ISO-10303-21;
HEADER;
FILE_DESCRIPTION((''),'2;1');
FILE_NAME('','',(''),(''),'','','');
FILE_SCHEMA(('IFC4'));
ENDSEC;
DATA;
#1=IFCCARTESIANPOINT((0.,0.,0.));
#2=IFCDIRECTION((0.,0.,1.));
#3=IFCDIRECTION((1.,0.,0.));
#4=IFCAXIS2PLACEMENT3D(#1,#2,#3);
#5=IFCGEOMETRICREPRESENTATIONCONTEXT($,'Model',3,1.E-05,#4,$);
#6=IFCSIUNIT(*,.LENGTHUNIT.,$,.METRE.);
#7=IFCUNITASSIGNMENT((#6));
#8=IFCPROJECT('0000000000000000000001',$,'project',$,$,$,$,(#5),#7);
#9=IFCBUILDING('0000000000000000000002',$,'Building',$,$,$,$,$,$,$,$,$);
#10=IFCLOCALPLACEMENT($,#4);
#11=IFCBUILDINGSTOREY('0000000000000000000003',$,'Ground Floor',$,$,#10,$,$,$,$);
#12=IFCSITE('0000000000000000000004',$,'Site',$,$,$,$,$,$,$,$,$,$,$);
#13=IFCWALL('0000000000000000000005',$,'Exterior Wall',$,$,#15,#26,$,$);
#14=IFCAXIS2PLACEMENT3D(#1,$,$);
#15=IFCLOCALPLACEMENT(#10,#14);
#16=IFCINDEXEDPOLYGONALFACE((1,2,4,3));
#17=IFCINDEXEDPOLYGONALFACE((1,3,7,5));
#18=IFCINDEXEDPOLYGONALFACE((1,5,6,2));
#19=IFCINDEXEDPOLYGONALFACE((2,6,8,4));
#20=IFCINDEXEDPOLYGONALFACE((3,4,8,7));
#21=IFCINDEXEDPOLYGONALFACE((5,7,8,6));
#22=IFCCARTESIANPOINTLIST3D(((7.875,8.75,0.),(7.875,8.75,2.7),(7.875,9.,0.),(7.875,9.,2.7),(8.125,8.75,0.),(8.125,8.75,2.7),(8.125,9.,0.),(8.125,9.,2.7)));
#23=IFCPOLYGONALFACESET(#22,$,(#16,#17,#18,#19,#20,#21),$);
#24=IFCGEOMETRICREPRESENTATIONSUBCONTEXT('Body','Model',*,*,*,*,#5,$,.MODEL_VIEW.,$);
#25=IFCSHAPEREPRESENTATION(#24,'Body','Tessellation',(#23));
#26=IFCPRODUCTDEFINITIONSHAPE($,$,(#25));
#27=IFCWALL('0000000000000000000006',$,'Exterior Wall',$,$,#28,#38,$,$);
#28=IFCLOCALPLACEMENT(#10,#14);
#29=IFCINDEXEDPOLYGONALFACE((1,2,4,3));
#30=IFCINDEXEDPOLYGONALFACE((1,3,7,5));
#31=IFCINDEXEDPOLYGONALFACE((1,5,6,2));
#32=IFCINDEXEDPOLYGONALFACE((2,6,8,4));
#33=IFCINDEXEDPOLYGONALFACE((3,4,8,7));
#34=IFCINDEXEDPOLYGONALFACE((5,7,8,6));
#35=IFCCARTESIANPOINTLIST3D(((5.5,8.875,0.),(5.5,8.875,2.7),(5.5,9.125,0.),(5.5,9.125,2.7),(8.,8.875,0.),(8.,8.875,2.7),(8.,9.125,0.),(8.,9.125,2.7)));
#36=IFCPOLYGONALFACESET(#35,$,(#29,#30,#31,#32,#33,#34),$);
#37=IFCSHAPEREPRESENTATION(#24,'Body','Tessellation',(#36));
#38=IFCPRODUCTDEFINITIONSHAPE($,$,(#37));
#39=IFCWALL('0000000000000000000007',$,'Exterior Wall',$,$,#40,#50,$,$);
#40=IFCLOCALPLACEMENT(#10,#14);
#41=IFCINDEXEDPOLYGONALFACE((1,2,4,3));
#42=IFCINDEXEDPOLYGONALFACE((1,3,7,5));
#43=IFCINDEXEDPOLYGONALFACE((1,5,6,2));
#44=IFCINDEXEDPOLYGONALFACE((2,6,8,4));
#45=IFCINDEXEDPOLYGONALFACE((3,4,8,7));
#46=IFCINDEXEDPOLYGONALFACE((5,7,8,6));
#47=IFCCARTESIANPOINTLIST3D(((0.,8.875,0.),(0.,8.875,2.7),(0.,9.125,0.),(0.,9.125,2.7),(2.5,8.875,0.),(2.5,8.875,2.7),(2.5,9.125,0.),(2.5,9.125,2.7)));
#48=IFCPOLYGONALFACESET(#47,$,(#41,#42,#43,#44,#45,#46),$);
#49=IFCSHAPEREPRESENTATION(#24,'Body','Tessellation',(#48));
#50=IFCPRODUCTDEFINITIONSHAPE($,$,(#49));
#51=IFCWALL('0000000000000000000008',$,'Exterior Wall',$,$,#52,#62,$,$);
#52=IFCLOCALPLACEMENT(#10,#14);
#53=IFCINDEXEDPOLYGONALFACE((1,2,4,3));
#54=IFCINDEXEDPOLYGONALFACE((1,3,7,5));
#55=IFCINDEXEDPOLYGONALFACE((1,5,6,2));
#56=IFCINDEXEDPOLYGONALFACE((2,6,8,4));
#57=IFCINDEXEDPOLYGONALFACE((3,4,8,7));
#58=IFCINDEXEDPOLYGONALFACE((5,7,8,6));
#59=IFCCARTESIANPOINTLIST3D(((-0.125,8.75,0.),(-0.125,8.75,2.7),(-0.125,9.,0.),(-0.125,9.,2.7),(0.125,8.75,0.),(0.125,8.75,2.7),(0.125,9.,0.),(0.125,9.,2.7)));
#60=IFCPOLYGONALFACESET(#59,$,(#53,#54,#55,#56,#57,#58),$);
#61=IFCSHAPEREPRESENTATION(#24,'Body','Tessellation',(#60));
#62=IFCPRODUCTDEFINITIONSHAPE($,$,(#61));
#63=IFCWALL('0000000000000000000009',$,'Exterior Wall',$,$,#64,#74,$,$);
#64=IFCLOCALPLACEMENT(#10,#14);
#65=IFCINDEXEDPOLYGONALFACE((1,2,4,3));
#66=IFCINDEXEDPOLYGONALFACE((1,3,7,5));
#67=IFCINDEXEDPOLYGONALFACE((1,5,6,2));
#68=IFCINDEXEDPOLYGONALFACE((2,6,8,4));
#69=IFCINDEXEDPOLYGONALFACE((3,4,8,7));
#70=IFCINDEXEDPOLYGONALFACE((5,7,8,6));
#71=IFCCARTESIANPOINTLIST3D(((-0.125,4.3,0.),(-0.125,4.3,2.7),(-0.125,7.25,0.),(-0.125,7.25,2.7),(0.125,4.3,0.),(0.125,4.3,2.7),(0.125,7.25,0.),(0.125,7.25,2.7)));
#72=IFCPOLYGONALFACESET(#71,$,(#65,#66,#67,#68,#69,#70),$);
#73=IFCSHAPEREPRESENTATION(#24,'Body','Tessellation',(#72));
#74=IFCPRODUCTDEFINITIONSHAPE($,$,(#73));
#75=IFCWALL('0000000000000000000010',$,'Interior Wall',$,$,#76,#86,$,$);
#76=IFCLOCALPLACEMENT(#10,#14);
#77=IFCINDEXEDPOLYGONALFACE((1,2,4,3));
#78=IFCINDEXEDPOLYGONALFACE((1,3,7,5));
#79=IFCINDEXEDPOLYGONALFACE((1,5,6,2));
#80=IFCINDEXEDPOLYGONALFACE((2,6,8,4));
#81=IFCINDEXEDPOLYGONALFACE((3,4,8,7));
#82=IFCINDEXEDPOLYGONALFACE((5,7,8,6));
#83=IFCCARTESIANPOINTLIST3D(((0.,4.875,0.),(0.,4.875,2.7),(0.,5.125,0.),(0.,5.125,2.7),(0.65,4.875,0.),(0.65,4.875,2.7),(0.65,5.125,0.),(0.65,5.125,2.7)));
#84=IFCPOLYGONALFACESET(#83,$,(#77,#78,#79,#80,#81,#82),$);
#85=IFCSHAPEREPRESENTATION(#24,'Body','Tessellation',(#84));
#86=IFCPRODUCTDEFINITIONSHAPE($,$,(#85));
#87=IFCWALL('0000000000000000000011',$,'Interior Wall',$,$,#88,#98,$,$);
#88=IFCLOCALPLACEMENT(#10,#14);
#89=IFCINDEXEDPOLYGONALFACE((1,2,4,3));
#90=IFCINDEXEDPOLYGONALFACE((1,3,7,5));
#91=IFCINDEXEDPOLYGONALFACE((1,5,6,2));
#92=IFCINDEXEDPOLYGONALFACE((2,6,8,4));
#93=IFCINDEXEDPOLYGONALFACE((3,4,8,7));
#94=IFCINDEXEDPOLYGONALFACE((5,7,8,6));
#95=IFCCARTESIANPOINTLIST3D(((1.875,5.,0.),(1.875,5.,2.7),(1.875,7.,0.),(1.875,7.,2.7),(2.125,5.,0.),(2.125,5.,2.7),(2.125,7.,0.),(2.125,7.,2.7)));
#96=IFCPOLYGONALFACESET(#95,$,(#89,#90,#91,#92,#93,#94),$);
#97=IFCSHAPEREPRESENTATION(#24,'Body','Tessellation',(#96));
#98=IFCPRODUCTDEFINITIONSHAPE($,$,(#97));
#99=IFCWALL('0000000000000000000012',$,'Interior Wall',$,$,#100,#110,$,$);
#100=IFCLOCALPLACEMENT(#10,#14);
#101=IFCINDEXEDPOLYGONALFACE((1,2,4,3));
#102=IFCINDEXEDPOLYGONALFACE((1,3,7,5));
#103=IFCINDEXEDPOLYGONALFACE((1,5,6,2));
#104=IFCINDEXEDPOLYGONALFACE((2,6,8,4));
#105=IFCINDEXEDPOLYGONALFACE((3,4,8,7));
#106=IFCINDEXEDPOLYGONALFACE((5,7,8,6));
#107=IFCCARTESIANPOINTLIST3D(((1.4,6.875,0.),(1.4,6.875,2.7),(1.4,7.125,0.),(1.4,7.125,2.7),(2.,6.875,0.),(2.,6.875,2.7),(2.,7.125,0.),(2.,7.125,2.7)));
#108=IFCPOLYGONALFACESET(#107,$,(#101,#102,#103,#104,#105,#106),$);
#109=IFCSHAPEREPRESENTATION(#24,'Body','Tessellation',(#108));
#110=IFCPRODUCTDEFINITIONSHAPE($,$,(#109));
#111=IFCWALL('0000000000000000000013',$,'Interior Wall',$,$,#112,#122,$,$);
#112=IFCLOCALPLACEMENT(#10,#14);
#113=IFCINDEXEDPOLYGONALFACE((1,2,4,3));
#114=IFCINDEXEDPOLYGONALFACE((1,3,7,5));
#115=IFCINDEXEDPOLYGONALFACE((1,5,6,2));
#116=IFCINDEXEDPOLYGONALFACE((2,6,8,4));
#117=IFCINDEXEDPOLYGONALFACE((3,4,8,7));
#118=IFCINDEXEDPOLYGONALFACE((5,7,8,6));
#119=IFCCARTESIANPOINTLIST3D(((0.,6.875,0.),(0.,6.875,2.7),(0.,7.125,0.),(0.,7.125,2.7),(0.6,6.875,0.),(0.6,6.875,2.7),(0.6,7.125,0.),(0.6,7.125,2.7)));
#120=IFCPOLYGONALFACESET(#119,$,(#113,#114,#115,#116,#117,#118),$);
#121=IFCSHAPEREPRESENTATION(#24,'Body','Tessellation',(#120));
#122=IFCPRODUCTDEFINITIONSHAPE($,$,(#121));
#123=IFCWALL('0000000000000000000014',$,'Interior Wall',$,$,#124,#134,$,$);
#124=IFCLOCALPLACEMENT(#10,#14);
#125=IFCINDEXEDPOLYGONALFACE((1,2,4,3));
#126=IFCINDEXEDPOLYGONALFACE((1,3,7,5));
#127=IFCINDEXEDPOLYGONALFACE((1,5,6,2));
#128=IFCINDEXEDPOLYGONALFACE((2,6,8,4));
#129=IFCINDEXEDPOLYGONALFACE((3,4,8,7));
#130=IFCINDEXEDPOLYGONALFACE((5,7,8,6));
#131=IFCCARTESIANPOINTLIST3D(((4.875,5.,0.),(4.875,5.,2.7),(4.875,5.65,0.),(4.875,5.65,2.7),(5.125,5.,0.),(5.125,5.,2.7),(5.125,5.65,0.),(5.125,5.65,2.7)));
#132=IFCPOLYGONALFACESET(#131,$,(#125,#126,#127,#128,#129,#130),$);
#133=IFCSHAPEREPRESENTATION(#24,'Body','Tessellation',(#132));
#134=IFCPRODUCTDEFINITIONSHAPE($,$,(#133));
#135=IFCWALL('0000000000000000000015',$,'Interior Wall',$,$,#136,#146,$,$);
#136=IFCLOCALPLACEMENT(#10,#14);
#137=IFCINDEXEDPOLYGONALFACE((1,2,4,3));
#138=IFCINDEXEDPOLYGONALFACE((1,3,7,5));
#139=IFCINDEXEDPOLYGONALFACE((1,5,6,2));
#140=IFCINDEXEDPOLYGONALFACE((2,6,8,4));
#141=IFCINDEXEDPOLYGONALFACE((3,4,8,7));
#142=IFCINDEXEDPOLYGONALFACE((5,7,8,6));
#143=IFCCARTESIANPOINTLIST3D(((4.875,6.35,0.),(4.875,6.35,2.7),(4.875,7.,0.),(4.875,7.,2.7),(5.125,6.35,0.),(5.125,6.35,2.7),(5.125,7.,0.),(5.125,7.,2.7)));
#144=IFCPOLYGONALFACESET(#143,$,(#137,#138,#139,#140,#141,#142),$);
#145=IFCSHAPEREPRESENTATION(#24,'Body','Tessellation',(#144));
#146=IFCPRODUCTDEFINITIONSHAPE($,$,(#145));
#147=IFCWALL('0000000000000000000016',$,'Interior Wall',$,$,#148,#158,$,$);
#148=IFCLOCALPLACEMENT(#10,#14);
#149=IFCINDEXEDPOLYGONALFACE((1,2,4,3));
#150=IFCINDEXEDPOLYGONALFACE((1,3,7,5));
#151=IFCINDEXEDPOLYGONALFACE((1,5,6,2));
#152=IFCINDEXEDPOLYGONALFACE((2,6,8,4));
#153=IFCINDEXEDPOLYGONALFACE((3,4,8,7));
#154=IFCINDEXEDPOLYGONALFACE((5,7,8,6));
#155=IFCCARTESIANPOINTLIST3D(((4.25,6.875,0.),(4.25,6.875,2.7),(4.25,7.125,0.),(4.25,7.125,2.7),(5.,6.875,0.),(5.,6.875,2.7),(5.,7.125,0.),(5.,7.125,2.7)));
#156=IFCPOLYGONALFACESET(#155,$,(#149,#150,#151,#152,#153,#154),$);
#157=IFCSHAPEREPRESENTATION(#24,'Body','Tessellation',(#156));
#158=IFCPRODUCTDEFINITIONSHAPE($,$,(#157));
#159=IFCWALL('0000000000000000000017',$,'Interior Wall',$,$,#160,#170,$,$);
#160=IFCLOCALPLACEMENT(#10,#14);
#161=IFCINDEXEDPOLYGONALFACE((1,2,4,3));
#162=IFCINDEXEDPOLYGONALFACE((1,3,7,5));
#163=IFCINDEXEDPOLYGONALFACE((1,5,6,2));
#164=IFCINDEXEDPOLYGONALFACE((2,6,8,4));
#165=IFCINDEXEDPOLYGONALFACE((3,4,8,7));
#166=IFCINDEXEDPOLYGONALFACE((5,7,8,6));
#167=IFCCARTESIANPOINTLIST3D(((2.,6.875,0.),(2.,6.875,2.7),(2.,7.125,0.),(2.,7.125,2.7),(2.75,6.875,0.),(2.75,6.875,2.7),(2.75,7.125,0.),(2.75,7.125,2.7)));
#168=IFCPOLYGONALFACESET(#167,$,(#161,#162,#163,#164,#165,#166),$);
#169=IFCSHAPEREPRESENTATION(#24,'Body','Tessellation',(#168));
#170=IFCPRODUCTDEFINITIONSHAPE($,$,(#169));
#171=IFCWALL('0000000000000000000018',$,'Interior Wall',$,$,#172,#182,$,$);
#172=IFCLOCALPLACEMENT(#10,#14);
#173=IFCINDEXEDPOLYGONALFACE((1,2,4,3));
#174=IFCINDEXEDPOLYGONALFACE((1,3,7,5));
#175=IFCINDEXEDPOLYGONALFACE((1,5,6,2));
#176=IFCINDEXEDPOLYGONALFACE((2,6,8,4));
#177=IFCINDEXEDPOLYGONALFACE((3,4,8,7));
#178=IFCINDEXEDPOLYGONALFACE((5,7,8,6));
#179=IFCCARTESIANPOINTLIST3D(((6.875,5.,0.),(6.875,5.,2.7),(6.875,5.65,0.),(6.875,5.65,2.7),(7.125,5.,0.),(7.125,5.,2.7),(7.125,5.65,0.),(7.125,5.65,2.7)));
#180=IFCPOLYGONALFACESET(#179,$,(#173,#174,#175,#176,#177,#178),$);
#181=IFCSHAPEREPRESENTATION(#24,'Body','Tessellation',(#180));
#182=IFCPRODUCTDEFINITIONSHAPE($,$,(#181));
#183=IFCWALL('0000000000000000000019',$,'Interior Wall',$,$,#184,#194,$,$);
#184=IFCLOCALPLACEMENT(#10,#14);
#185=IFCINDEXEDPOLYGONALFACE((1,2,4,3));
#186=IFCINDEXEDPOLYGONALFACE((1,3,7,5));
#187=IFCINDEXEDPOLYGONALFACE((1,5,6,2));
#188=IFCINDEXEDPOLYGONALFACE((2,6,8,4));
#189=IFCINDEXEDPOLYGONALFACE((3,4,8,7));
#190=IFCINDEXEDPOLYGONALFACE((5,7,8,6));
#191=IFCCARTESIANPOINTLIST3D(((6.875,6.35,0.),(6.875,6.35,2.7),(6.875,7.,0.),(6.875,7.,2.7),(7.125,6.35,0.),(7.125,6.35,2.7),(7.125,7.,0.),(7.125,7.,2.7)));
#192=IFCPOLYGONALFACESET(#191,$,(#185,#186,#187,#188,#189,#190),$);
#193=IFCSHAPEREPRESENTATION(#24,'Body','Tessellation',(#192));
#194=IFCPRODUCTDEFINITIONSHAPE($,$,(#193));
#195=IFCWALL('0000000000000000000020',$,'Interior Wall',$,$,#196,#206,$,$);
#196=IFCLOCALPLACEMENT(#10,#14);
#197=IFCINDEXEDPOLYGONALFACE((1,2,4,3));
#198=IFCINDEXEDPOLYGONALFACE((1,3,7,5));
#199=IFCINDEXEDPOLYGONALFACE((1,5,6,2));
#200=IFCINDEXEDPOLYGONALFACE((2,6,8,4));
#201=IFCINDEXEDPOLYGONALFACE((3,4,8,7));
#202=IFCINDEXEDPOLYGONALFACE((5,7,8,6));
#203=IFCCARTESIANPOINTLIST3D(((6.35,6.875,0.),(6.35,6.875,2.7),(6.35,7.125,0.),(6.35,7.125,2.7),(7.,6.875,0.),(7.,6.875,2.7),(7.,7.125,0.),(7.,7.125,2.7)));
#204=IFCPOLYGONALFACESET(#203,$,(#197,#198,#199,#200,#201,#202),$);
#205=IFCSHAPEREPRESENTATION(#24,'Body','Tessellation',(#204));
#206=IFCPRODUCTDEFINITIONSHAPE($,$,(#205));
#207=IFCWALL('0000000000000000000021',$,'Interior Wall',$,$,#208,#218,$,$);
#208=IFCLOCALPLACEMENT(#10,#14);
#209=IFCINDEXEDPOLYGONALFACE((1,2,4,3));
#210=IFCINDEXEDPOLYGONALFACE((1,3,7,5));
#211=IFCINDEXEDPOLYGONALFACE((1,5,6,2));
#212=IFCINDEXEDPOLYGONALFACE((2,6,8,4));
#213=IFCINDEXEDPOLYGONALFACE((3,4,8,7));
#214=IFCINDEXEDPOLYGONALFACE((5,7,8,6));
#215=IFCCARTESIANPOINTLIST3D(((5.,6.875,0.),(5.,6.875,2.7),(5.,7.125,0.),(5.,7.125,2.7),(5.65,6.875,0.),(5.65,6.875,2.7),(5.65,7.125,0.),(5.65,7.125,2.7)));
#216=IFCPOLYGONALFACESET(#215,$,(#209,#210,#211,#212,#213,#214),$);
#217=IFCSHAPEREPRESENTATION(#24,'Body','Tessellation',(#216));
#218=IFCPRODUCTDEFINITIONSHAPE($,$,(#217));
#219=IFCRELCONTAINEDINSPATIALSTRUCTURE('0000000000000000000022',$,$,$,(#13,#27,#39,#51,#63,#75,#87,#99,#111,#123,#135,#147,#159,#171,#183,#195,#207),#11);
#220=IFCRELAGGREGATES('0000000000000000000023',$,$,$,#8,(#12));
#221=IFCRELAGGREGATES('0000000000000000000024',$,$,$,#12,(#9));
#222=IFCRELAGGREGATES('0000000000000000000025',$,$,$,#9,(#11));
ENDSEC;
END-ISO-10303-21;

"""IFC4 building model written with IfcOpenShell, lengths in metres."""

from ifc_helpers import new_model, si_unit, frame, origin_with_axes, place, context, subcontext, project, spatial, indexed_curve, outline, extrude, element, save


model = new_model("IFC4")

# Units and contexts
model_context = context("Model", 3, precision=1e-05, world=origin_with_axes())
body_context = subcontext(model_context, "Body", "Model", "MODEL_VIEW")
ifc_project = project(units=[si_unit("LENGTHUNIT", "METRE")], contexts=[model_context])

# Site, building, storey
site = spatial("IfcSite", under=ifc_project, Name="Site")
building = spatial("IfcBuilding", under=site, Name="Building")
storey_placement = place(None, origin_with_axes())
storey = spatial("IfcBuildingStorey", under=building, at=storey_placement, Name="Ground Floor")

# Walls
wall_1_placement = place(storey_placement, frame((8.0, 8.75, 0.0), z_axis=(0.0, 0.0, 1.0), x_axis=(0.0, 1.0, 0.0)))
element("IfcWall", 1, at=wall_1_placement, inside=storey, Name="Exterior Wall", context=body_context, shape_type="SweptSolid", body=[
    extrude(outline(indexed_curve([(0.0, 0.0), (0.0, 0.25), (0.25, 0.25), (0.25, 0.0), (0.0, 0.0)], self_intersect=False)), frame((0.0, -0.125, 0.0), z_axis=(0.0, 0.0, 1.0), x_axis=(1.0, 0.0, 0.0)), (0.0, 0.0, 1.0), 2.7),
])
for number, where, z_axis, x_axis, name in (
    (2, (8.0, 9.0, 0.0), (0.0, 0.0, 1.0), (-1.0, 0.0, 0.0), "Exterior Wall"),
    (3, (2.5, 9.0, 0.0), (0.0, 0.0, 1.0), (-1.0, 0.0, 0.0), "Exterior Wall"),
):
    element("IfcWall", number, at=place(storey_placement, frame(where, z_axis=z_axis, x_axis=x_axis)), inside=storey, Name=name, context=body_context, shape_type="SweptSolid", body=[
        extrude(outline(indexed_curve([(0.0, 0.0), (0.0, 0.25), (2.5, 0.25), (2.5, 0.0), (0.0, 0.0)], self_intersect=False)), frame((0.0, -0.125, 0.0), z_axis=(0.0, 0.0, 1.0), x_axis=(1.0, 0.0, 0.0)), (0.0, 0.0, 1.0), 2.7),
    ])
wall_2_placement = place(storey_placement, frame((0.0, 9.0, 0.0), z_axis=(0.0, 0.0, 1.0), x_axis=(0.0, -1.0, 0.0)))
element("IfcWall", 4, at=wall_2_placement, inside=storey, Name="Exterior Wall", context=body_context, shape_type="SweptSolid", body=[
    extrude(outline(indexed_curve([(0.0, 0.0), (0.0, 0.25), (0.25, 0.25), (0.25, 0.0), (0.0, 0.0)], self_intersect=False)), frame((0.0, -0.125, 0.0), z_axis=(0.0, 0.0, 1.0), x_axis=(1.0, 0.0, 0.0)), (0.0, 0.0, 1.0), 2.7),
])
wall_3_placement = place(storey_placement, frame((0.0, 7.25, 0.0), z_axis=(0.0, 0.0, 1.0), x_axis=(0.0, -1.0, 0.0)))
element("IfcWall", 5, at=wall_3_placement, inside=storey, Name="Exterior Wall", context=body_context, shape_type="SweptSolid", body=[
    extrude(outline(indexed_curve([(0.0, 0.0), (0.0, 0.25), (2.95, 0.25), (2.95, 0.0), (0.0, 0.0)], self_intersect=False)), frame((0.0, -0.125, 0.0), z_axis=(0.0, 0.0, 1.0), x_axis=(1.0, 0.0, 0.0)), (0.0, 0.0, 1.0), 2.7),
])
wall_4_placement = place(storey_placement, frame((0.65, 5.0, 0.0), z_axis=(0.0, 0.0, 1.0), x_axis=(-1.0, 0.0, 0.0)))
element("IfcWall", 6, at=wall_4_placement, inside=storey, Name="Interior Wall", context=body_context, shape_type="SweptSolid", body=[
    extrude(outline(indexed_curve([(0.0, 0.0), (0.0, 0.25), (0.65, 0.25), (0.65, 0.0), (0.0, 0.0)], self_intersect=False)), frame((0.0, -0.125, 0.0), z_axis=(0.0, 0.0, 1.0), x_axis=(1.0, 0.0, 0.0)), (0.0, 0.0, 1.0), 2.7),
])
wall_5_placement = place(storey_placement, frame((2.0, 5.0, 0.0), z_axis=(0.0, 0.0, 1.0), x_axis=(0.0, 1.0, 0.0)))
element("IfcWall", 7, at=wall_5_placement, inside=storey, Name="Interior Wall", context=body_context, shape_type="SweptSolid", body=[
    extrude(outline(indexed_curve([(0.0, 0.0), (0.0, 0.25), (2.0, 0.25), (2.0, 0.0), (0.0, 0.0)], self_intersect=False)), frame((0.0, -0.125, 0.0), z_axis=(0.0, 0.0, 1.0), x_axis=(1.0, 0.0, 0.0)), (0.0, 0.0, 1.0), 2.7),
])
for number, where, z_axis, x_axis, name in (
    (8, (2.0, 7.0, 0.0), (0.0, 0.0, 1.0), (-1.0, 0.0, 0.0), "Interior Wall"),
    (9, (0.6, 7.0, 0.0), (0.0, 0.0, 1.0), (-1.0, 0.0, 0.0), "Interior Wall"),
):
    element("IfcWall", number, at=place(storey_placement, frame(where, z_axis=z_axis, x_axis=x_axis)), inside=storey, Name=name, context=body_context, shape_type="SweptSolid", body=[
        extrude(outline(indexed_curve([(0.0, 0.0), (0.0, 0.25), (0.6, 0.25), (0.6, 0.0), (0.0, 0.0)], self_intersect=False)), frame((0.0, -0.125, 0.0), z_axis=(0.0, 0.0, 1.0), x_axis=(1.0, 0.0, 0.0)), (0.0, 0.0, 1.0), 2.7),
    ])
for number, where, z_axis, x_axis, name in (
    (10, (5.0, 5.0, 0.0), (0.0, 0.0, 1.0), (0.0, 1.0, 0.0), "Interior Wall"),
    (11, (5.0, 6.35, 0.0), (0.0, 0.0, 1.0), (0.0, 1.0, 0.0), "Interior Wall"),
):
    element("IfcWall", number, at=place(storey_placement, frame(where, z_axis=z_axis, x_axis=x_axis)), inside=storey, Name=name, context=body_context, shape_type="SweptSolid", body=[
        extrude(outline(indexed_curve([(0.0, 0.0), (0.0, 0.25), (0.65, 0.25), (0.65, 0.0), (0.0, 0.0)], self_intersect=False)), frame((0.0, -0.125, 0.0), z_axis=(0.0, 0.0, 1.0), x_axis=(1.0, 0.0, 0.0)), (0.0, 0.0, 1.0), 2.7),
    ])
for number, where, z_axis, x_axis, name in (
    (12, (5.0, 7.0, 0.0), (0.0, 0.0, 1.0), (-1.0, 0.0, 0.0), "Interior Wall"),
    (13, (2.75, 7.0, 0.0), (0.0, 0.0, 1.0), (-1.0, 0.0, 0.0), "Interior Wall"),
):
    element("IfcWall", number, at=place(storey_placement, frame(where, z_axis=z_axis, x_axis=x_axis)), inside=storey, Name=name, context=body_context, shape_type="SweptSolid", body=[
        extrude(outline(indexed_curve([(0.0, 0.0), (0.0, 0.25), (0.75, 0.25), (0.75, 0.0), (0.0, 0.0)], self_intersect=False)), frame((0.0, -0.125, 0.0), z_axis=(0.0, 0.0, 1.0), x_axis=(1.0, 0.0, 0.0)), (0.0, 0.0, 1.0), 2.7),
    ])
for number, where, z_axis, x_axis, name in (
    (14, (7.0, 5.0, 0.0), (0.0, 0.0, 1.0), (0.0, 1.0, 0.0), "Interior Wall"),
    (15, (7.0, 6.35, 0.0), (0.0, 0.0, 1.0), (0.0, 1.0, 0.0), "Interior Wall"),
    (16, (7.0, 7.0, 0.0), (0.0, 0.0, 1.0), (-1.0, 0.0, 0.0), "Interior Wall"),
    (17, (5.65, 7.0, 0.0), (0.0, 0.0, 1.0), (-1.0, 0.0, 0.0), "Interior Wall"),
):
    element("IfcWall", number, at=place(storey_placement, frame(where, z_axis=z_axis, x_axis=x_axis)), inside=storey, Name=name, context=body_context, shape_type="SweptSolid", body=[
        extrude(outline(indexed_curve([(0.0, 0.0), (0.0, 0.25), (0.65, 0.25), (0.65, 0.0), (0.0, 0.0)], self_intersect=False)), frame((0.0, -0.125, 0.0), z_axis=(0.0, 0.0, 1.0), x_axis=(1.0, 0.0, 0.0)), (0.0, 0.0, 1.0), 2.7),
    ])

save(model, "model.ifc")
